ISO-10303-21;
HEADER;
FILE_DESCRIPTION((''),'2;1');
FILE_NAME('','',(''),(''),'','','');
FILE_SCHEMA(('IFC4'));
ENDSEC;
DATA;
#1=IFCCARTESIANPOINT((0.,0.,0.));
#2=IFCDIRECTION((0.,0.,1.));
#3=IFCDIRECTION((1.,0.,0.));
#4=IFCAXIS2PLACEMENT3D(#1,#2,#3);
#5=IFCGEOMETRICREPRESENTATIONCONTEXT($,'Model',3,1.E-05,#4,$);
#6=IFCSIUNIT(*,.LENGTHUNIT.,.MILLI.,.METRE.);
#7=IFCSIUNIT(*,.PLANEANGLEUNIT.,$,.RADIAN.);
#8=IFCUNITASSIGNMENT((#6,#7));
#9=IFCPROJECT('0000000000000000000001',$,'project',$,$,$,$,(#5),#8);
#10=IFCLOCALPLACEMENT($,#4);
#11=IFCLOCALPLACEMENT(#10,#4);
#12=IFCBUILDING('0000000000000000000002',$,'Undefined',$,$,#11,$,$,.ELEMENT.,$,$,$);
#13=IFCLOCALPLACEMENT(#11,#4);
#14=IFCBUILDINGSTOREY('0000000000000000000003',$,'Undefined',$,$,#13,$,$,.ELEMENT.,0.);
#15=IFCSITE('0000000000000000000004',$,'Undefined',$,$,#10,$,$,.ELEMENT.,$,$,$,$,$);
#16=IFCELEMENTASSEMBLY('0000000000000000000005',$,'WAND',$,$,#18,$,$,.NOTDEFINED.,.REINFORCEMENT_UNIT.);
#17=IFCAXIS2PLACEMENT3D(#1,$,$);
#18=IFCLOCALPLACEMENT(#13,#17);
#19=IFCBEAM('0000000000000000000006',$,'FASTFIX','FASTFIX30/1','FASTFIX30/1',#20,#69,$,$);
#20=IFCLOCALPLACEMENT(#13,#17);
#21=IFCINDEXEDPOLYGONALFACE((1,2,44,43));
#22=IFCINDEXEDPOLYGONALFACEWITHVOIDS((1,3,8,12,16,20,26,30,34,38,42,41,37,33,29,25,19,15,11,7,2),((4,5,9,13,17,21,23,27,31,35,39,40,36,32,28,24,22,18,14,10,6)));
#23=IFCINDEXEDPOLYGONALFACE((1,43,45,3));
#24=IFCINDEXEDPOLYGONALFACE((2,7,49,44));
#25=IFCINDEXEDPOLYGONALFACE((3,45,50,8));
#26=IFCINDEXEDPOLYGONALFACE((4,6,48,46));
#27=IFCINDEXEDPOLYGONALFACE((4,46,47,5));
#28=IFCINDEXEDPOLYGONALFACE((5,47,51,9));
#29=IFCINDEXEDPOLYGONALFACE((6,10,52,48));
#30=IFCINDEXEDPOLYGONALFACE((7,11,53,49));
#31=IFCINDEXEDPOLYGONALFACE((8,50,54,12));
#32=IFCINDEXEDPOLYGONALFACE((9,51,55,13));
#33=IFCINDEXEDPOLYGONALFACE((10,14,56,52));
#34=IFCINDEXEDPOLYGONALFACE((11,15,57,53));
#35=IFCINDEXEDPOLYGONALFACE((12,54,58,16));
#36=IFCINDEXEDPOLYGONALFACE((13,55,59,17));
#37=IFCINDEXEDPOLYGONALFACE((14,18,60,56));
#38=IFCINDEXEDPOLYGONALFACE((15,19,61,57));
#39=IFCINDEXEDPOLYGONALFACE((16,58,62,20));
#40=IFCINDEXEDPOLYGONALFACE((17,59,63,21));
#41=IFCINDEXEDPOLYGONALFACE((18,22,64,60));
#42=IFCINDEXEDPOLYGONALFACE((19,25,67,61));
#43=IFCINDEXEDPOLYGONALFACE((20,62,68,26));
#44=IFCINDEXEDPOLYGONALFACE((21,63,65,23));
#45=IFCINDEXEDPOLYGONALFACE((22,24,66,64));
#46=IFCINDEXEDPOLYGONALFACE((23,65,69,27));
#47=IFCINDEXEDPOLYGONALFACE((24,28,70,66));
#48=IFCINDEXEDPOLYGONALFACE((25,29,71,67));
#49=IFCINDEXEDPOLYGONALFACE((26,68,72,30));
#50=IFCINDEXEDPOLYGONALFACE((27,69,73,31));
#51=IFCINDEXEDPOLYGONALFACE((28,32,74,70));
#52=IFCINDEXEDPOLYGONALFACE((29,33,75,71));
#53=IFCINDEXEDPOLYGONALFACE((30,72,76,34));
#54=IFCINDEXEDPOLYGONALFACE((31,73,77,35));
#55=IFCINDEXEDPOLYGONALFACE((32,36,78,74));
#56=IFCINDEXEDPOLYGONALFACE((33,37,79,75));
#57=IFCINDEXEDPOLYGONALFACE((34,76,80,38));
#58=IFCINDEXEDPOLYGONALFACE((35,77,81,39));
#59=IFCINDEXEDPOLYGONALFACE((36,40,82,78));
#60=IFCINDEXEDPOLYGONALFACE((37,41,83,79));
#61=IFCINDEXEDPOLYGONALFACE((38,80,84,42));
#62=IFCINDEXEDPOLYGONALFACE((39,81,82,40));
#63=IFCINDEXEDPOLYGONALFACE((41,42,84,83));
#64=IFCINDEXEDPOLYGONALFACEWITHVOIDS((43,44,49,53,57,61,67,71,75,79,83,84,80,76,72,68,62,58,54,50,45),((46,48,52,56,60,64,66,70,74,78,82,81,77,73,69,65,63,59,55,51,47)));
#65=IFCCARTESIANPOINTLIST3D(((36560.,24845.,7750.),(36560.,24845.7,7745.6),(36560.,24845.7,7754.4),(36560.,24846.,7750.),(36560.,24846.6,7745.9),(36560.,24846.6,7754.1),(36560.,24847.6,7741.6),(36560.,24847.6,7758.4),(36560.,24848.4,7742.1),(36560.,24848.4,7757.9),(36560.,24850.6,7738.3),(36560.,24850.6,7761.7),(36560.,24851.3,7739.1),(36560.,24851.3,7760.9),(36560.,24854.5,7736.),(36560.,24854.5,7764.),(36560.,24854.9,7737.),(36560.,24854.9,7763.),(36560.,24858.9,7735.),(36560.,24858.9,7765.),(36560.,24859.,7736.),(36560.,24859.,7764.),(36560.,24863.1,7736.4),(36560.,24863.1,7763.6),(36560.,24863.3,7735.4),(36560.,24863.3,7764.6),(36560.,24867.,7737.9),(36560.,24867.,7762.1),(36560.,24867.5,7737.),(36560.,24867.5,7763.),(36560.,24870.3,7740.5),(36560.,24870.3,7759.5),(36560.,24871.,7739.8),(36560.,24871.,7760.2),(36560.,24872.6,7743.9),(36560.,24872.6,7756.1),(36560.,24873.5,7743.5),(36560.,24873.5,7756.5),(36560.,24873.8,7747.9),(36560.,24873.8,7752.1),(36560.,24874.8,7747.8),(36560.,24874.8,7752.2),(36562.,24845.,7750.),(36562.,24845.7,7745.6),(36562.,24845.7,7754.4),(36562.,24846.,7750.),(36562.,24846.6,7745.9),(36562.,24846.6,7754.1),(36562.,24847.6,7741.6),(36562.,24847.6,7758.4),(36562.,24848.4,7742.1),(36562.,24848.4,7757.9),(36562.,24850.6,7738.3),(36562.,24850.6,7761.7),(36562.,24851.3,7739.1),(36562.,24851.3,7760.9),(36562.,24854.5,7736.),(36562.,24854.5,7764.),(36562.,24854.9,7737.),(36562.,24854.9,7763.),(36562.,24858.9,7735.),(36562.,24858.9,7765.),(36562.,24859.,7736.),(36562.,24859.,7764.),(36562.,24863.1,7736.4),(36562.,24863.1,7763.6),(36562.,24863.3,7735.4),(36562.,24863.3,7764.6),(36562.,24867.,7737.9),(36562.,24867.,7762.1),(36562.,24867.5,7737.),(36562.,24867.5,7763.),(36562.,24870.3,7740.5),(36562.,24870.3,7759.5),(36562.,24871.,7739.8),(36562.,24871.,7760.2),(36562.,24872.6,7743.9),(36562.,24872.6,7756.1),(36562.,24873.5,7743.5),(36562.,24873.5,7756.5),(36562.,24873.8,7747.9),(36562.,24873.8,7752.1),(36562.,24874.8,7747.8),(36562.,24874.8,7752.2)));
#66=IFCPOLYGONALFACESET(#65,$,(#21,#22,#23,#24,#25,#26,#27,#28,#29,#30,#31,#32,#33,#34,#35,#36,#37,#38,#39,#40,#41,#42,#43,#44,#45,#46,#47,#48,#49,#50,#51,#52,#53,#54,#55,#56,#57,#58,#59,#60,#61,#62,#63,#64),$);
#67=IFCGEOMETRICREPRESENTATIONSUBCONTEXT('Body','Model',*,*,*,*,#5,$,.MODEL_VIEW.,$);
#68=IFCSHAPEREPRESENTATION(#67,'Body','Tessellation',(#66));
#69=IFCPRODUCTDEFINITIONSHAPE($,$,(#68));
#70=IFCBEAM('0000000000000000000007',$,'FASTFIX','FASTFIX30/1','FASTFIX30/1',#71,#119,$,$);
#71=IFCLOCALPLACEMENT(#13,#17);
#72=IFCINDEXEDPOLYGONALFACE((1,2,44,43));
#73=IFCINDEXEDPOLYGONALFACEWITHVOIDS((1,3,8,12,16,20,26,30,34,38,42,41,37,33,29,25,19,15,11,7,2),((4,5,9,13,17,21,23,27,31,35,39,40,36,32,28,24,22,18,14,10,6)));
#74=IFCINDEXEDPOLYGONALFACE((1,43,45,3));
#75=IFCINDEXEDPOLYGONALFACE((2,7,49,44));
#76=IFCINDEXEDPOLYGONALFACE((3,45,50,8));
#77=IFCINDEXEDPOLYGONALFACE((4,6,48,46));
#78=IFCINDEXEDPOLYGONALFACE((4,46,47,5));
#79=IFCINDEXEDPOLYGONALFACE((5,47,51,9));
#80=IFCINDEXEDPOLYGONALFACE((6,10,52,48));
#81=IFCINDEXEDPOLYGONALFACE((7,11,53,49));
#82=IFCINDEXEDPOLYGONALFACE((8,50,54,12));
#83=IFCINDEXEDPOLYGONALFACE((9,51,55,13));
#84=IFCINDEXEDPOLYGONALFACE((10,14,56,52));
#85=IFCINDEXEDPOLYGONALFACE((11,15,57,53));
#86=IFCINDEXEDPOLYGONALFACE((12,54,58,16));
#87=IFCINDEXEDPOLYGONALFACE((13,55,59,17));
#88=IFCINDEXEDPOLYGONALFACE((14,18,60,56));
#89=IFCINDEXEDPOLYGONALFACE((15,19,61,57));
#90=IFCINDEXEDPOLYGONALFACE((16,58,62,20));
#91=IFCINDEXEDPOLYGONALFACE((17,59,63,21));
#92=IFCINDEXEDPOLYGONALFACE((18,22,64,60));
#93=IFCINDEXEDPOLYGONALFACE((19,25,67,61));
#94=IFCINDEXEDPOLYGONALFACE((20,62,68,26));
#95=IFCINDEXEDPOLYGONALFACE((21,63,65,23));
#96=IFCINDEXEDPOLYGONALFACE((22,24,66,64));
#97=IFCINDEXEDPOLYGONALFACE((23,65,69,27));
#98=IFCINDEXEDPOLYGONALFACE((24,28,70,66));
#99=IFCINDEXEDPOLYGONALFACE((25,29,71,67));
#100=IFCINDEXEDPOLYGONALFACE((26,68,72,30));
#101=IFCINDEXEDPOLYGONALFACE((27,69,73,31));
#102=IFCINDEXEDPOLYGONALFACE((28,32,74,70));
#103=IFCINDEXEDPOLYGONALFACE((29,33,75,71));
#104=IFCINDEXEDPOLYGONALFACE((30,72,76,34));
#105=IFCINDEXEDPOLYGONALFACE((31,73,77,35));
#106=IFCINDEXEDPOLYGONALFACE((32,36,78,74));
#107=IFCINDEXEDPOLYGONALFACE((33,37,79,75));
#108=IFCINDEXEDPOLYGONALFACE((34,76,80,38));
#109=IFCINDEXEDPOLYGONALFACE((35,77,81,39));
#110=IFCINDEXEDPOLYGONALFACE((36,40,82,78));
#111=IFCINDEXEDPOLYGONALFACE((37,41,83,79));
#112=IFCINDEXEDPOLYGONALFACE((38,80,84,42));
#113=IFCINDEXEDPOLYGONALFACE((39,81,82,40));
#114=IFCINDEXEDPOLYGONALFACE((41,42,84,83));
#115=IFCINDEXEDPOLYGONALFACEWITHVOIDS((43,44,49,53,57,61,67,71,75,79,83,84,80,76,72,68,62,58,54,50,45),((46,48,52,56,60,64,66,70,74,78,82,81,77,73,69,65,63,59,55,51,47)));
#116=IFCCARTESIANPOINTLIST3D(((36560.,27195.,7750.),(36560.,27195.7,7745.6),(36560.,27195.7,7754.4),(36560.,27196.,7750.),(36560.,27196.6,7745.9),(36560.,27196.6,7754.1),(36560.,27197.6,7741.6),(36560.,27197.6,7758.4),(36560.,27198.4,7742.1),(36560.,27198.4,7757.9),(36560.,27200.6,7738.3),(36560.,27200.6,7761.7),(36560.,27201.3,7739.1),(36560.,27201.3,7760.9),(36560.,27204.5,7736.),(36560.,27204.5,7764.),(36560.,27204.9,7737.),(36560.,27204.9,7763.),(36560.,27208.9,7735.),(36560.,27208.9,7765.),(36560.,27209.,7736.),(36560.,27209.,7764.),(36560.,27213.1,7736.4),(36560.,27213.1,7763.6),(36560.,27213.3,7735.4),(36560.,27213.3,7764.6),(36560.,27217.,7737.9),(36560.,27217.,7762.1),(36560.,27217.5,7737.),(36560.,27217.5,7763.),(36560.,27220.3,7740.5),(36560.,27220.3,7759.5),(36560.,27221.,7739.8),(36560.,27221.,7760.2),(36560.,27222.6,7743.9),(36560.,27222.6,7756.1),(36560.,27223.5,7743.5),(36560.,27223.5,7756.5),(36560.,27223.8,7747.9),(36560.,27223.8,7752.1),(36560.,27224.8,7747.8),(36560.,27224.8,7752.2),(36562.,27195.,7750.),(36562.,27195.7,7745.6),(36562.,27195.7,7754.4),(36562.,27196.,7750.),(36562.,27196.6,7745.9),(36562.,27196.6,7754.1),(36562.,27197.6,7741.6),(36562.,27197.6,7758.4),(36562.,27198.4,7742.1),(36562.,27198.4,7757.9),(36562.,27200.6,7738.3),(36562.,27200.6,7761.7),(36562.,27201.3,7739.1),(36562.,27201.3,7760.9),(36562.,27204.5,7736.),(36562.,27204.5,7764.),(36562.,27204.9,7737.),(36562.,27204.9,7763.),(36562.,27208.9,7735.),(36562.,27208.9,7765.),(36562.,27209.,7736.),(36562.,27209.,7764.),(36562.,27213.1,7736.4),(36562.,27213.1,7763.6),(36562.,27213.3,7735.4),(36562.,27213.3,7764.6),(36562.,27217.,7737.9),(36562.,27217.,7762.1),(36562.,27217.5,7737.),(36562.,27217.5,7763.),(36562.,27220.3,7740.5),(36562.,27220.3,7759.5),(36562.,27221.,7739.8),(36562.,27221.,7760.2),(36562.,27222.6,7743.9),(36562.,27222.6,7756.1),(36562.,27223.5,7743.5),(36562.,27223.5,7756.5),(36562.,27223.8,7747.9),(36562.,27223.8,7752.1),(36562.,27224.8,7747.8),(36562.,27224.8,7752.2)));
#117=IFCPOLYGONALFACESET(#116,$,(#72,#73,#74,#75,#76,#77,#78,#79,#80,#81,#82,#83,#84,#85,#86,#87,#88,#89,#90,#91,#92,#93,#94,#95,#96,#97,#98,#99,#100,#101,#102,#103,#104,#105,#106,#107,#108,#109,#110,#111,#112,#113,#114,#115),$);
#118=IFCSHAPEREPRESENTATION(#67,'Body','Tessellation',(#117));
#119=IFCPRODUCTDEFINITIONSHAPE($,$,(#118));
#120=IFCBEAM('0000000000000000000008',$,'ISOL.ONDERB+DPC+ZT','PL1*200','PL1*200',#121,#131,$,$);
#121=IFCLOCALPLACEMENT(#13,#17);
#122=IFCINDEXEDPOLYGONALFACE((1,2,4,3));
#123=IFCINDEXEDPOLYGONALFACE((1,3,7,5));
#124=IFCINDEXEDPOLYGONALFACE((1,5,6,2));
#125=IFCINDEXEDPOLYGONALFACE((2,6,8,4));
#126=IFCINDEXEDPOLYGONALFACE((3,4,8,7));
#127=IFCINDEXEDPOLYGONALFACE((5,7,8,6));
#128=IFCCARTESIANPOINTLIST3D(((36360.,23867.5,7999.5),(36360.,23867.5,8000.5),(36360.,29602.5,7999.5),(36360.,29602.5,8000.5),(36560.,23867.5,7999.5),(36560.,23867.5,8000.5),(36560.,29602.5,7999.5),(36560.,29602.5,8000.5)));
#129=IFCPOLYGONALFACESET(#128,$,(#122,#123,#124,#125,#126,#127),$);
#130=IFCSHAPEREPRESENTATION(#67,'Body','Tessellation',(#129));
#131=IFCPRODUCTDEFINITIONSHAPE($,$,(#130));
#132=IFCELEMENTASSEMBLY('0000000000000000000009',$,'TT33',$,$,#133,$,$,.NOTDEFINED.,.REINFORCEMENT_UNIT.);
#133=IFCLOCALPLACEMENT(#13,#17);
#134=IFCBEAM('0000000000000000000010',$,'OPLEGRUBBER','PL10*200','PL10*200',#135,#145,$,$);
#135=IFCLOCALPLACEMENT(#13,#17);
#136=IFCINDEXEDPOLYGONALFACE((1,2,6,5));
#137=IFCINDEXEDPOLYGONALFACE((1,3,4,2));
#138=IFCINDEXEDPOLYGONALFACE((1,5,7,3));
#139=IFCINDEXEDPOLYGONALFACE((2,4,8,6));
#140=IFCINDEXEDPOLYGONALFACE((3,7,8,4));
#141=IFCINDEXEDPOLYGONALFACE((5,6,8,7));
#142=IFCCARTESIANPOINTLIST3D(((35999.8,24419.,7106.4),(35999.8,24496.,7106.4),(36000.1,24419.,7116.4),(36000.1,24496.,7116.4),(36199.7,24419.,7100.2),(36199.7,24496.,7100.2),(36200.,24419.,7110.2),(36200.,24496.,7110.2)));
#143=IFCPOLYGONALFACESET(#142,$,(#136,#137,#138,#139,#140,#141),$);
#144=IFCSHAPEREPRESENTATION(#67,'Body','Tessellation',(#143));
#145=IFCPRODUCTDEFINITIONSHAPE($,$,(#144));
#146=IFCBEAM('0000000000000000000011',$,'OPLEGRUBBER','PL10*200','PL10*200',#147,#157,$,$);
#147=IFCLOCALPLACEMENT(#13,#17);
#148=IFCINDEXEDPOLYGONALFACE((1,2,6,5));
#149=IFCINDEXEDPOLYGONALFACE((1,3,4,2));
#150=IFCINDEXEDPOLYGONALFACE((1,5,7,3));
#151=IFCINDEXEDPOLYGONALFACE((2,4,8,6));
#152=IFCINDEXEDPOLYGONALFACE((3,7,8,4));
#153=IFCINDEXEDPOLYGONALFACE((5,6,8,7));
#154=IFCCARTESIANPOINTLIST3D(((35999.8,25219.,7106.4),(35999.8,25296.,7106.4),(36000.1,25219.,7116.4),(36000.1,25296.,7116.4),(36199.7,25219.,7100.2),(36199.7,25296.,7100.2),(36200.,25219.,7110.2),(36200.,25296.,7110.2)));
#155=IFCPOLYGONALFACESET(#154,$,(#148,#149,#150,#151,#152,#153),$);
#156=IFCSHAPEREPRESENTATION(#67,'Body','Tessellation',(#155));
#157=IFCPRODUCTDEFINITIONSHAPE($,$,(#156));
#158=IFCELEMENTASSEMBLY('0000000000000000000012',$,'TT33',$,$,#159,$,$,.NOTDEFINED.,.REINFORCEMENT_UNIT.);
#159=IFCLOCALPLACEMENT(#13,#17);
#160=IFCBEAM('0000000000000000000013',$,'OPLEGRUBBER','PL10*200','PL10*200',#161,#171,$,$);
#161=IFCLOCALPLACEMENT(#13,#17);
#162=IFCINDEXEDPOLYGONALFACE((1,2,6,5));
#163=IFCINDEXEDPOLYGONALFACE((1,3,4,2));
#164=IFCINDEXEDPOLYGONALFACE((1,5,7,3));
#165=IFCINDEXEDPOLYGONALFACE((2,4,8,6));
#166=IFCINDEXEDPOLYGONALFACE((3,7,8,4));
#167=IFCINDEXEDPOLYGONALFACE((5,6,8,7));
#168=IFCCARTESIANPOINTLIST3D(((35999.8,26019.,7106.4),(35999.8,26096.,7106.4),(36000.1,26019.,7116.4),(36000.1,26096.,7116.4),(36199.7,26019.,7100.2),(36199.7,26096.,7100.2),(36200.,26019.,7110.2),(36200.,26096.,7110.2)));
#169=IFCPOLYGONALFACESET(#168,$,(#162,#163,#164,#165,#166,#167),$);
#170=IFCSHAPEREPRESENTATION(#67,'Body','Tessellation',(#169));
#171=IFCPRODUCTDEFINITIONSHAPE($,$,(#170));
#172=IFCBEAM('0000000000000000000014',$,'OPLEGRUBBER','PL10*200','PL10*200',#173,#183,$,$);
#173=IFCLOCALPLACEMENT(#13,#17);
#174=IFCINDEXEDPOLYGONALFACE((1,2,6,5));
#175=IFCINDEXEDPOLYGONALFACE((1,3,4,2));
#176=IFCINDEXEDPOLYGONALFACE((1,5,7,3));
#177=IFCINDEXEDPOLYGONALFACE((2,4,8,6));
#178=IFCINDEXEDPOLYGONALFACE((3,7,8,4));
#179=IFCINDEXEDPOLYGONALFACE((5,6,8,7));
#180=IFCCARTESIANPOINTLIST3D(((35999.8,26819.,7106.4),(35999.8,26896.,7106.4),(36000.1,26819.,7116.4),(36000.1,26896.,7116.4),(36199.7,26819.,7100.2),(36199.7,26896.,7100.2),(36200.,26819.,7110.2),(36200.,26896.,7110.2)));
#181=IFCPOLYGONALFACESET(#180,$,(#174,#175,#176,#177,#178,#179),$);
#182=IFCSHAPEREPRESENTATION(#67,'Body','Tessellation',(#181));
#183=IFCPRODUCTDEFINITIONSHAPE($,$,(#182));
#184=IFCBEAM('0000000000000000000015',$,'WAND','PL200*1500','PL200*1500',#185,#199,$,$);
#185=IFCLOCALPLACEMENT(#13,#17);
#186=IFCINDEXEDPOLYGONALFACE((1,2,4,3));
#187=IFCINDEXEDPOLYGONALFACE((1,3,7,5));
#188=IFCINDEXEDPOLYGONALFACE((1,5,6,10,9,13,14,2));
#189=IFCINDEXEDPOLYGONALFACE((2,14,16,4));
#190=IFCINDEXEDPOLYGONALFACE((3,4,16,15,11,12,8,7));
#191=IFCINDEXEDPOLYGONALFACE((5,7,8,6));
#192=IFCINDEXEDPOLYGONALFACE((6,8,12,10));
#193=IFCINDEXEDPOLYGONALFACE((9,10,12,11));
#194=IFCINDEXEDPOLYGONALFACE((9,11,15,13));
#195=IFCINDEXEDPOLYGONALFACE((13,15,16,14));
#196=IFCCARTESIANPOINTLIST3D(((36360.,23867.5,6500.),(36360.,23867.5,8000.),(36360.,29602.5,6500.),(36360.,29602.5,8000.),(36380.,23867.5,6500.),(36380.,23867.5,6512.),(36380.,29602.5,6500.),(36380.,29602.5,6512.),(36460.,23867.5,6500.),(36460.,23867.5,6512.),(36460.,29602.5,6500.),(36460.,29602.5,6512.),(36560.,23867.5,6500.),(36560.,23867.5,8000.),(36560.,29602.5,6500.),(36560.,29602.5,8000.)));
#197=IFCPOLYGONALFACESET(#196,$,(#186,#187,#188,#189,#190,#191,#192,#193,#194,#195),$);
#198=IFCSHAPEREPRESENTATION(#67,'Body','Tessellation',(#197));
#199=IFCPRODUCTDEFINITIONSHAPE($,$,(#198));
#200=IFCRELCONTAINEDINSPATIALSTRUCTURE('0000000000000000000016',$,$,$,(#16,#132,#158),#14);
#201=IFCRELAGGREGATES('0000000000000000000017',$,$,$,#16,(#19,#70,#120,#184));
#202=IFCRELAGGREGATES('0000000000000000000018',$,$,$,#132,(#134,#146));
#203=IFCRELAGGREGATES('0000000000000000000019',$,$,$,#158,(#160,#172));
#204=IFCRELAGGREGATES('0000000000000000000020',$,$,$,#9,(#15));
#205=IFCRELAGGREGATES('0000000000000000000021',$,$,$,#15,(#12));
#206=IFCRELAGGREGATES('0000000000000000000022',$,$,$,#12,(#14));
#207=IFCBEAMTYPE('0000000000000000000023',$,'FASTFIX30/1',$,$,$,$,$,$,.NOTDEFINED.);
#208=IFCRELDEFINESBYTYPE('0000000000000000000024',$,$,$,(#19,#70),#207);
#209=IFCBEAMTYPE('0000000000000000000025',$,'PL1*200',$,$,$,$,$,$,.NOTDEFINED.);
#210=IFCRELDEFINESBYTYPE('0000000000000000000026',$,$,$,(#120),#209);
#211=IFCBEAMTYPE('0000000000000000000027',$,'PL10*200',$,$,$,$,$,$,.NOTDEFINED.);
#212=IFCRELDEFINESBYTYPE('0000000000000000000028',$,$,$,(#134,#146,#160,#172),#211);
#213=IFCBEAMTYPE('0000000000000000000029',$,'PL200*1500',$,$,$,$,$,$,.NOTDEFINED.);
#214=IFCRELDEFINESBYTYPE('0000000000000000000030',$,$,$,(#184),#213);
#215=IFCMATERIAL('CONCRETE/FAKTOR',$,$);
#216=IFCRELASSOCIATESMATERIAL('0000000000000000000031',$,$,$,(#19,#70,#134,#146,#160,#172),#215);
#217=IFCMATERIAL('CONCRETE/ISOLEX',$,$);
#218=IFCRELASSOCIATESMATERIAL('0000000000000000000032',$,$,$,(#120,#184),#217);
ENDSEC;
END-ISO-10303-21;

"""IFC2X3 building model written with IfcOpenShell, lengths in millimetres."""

from ifc_helpers import new_model, si_unit, frame, frame_2d, origin_with_axes, place, context, subcontext, project, spatial, rectangle, hollow_circle, extrude, boolean, material, type_object, element, aggregate, save


model = new_model("IFC2X3")

# Units and contexts
model_context = context("Model", 3, precision=1e-05, world=origin_with_axes())
body_context = subcontext(model_context, "Body", "Model", "MODEL_VIEW")
ifc_project = project(units=[si_unit("LENGTHUNIT", "METRE", prefix="MILLI"), si_unit("PLANEANGLEUNIT", "RADIAN")], contexts=[model_context])

# Site, building, storey
site_placement = place(None, origin_with_axes())
site = spatial("IfcSite", under=ifc_project, at=site_placement, Name="Undefined", CompositionType="ELEMENT")
building_placement = place(site_placement, origin_with_axes())
building = spatial("IfcBuilding", under=site, at=building_placement, Name="Undefined", CompositionType="ELEMENT")
storey_placement = place(building_placement, origin_with_axes())
storey = spatial("IfcBuildingStorey", under=building, at=storey_placement, Name="Undefined", CompositionType="ELEMENT", Elevation=0.0)

# Shared definitions
ifc_material_1 = material(Name="CONCRETE/FAKTOR")

# Element assembly
assembly_1_placement = place(storey_placement, origin_with_axes())
assembly_1 = element("IfcElementAssembly", 1, at=assembly_1_placement, inside=storey, Name="WAND", AssemblyPlace="NOTDEFINED", PredefinedType="REINFORCEMENT_UNIT")

# Beams
beam_type_1 = type_object("IfcBeamType", Name="FASTFIX30/1", PredefinedType="NOTDEFINED")
beam_1_placement = place(assembly_1_placement, frame((36560.0, 24860.0, 7750.0), z_axis=(0.0, 0.0, 1.0), x_axis=(1.0, 0.0, 0.0)))
beam_1 = element("IfcBeam", 2, at=beam_1_placement, type_object=beam_type_1, material=ifc_material_1, Name="FASTFIX", Description="FASTFIX30/1", ObjectType="FASTFIX30/1", context=body_context, shape_type="SweptSolid", body=[
    extrude(hollow_circle(Radius=15.0, WallThickness=1.0, at=frame_2d((0.0, 0.0), x_axis=(1.0, 0.0))), frame((2.0, 0.0, 0.0), z_axis=(-1.0, 0.0, 0.0), x_axis=(0.0, -1.0, 0.0)), (0.0, 0.0, 1.0), 2.0),
])
beam_2_placement = place(assembly_1_placement, frame((36560.0, 27210.0, 7750.0), z_axis=(0.0, 0.0, 1.0), x_axis=(1.0, 0.0, 0.0)))
beam_2 = element("IfcBeam", 3, at=beam_2_placement, type_object=beam_type_1, material=ifc_material_1, Name="FASTFIX", Description="FASTFIX30/1", ObjectType="FASTFIX30/1", context=body_context, shape_type="SweptSolid", body=[
    extrude(hollow_circle(Radius=15.0, WallThickness=1.0, at=frame_2d((0.0, 0.0), x_axis=(1.0, 0.0))), frame((2.0, 0.0, 0.0), z_axis=(-1.0, 0.0, 0.0), x_axis=(0.0, -1.0, 0.0)), (0.0, 0.0, 1.0), 2.0),
])
ifc_material_2 = material(Name="CONCRETE/ISOLEX")
beam_type_2 = type_object("IfcBeamType", Name="PL1*200", PredefinedType="NOTDEFINED")
beam_3_placement = place(assembly_1_placement, frame((36460.0, 23867.5, 8000.0), z_axis=(1.0, 0.0, 0.0), x_axis=(0.0, 1.0, 0.0)))
beam_3 = element("IfcBeam", 4, at=beam_3_placement, type_object=beam_type_2, material=ifc_material_2, Name="ISOL.ONDERB+DPC+ZT", Description="PL1*200", ObjectType="PL1*200", context=body_context, shape_type="SweptSolid", body=[
    extrude(rectangle(XDim=1.0, YDim=200.0, at=frame_2d((0.0, 0.0), x_axis=(1.0, 0.0))), frame((5735.0, 0.0, 0.0), z_axis=(-1.0, 0.0, 0.0), x_axis=(0.0, -1.0, 0.0)), (0.0, 0.0, 1.0), 5735.0),
])

# Element assemblies, beams
assembly_2_placement = place(storey_placement, origin_with_axes())
assembly_2 = element("IfcElementAssembly", 5, at=assembly_2_placement, inside=storey, Name="TT33", AssemblyPlace="NOTDEFINED", PredefinedType="REINFORCEMENT_UNIT")
beam_type_3 = type_object("IfcBeamType", Name="PL10*200", PredefinedType="NOTDEFINED")
beam_4_placement = place(assembly_2_placement, frame((36099.9, 24496.0, 7108.3), z_axis=(-0.999516, 0.0, 0.031107), x_axis=(0.0, -1.0, 0.0)))
beam_4 = element("IfcBeam", 6, at=beam_4_placement, type_object=beam_type_3, material=ifc_material_1, Name="OPLEGRUBBER", Description="PL10*200", ObjectType="PL10*200", context=body_context, shape_type="SweptSolid", body=[
    extrude(rectangle(XDim=10.0, YDim=200.0, at=frame_2d((0.0, 0.0), x_axis=(1.0, 0.0))), frame((77.0, 0.0, 0.0), z_axis=(-1.0, 0.0, 0.0), x_axis=(0.0, -1.0, 0.0)), (0.0, 0.0, 1.0), 77.0),
])
beam_5_placement = place(assembly_2_placement, frame((36099.9, 25296.0, 7108.3), z_axis=(-0.999516, 0.0, 0.031107), x_axis=(0.0, -1.0, 0.0)))
beam_5 = element("IfcBeam", 7, at=beam_5_placement, type_object=beam_type_3, material=ifc_material_1, Name="OPLEGRUBBER", Description="PL10*200", ObjectType="PL10*200", context=body_context, shape_type="SweptSolid", body=[
    extrude(rectangle(XDim=10.0, YDim=200.0, at=frame_2d((0.0, 0.0), x_axis=(1.0, 0.0))), frame((77.0, 0.0, 0.0), z_axis=(-1.0, 0.0, 0.0), x_axis=(0.0, -1.0, 0.0)), (0.0, 0.0, 1.0), 77.0),
])
assembly_3_placement = place(storey_placement, origin_with_axes())
assembly_3 = element("IfcElementAssembly", 8, at=assembly_3_placement, inside=storey, Name="TT33", AssemblyPlace="NOTDEFINED", PredefinedType="REINFORCEMENT_UNIT")
beam_6_placement = place(assembly_3_placement, frame((36099.9, 26096.0, 7108.3), z_axis=(-0.999516, 0.0, 0.031107), x_axis=(0.0, -1.0, 0.0)))
beam_6 = element("IfcBeam", 9, at=beam_6_placement, type_object=beam_type_3, material=ifc_material_1, Name="OPLEGRUBBER", Description="PL10*200", ObjectType="PL10*200", context=body_context, shape_type="SweptSolid", body=[
    extrude(rectangle(XDim=10.0, YDim=200.0, at=frame_2d((0.0, 0.0), x_axis=(1.0, 0.0))), frame((77.0, 0.0, 0.0), z_axis=(-1.0, 0.0, 0.0), x_axis=(0.0, -1.0, 0.0)), (0.0, 0.0, 1.0), 77.0),
])
beam_7_placement = place(assembly_3_placement, frame((36099.9, 26896.0, 7108.3), z_axis=(-0.999516, 0.0, 0.031107), x_axis=(0.0, -1.0, 0.0)))
beam_7 = element("IfcBeam", 10, at=beam_7_placement, type_object=beam_type_3, material=ifc_material_1, Name="OPLEGRUBBER", Description="PL10*200", ObjectType="PL10*200", context=body_context, shape_type="SweptSolid", body=[
    extrude(rectangle(XDim=10.0, YDim=200.0, at=frame_2d((0.0, 0.0), x_axis=(1.0, 0.0))), frame((77.0, 0.0, 0.0), z_axis=(-1.0, 0.0, 0.0), x_axis=(0.0, -1.0, 0.0)), (0.0, 0.0, 1.0), 77.0),
])

# Beam
beam_type_4 = type_object("IfcBeamType", Name="PL200*1500", PredefinedType="NOTDEFINED")
beam_8_placement = place(assembly_1_placement, frame((36460.0, 23867.5, 7250.0), z_axis=(0.0, 0.0, 1.0), x_axis=(0.0, 1.0, 0.0)))
beam_8 = element("IfcBeam", 11, at=beam_8_placement, type_object=beam_type_4, material=ifc_material_2, Name="WAND", Description="PL200*1500", ObjectType="PL200*1500", context=body_context, shape_type="CSG", body=[
    boolean("DIFFERENCE", extrude(rectangle(XDim=200.0, YDim=1500.0, at=frame_2d((0.0, 0.0), x_axis=(1.0, 0.0))), frame((5735.0, 0.0, 0.0), z_axis=(-1.0, 0.0, 0.0), x_axis=(0.0, -1.0, 0.0)), (0.0, 0.0, 1.0), 5735.0), extrude(rectangle(XDim=12.0, YDim=80.0, at=frame_2d((0.0, 0.0), x_axis=(1.0, 0.0))), frame((5735.0, 40.0, -744.0), z_axis=(-1.0, 0.0, 0.0), x_axis=(0.0, 0.0, -1.0)), (0.0, 0.0, 1.0), 5735.0)),
])
aggregate(assembly_1, [beam_1, beam_2, beam_3, beam_8])

aggregate(assembly_2, [beam_4, beam_5])
aggregate(assembly_3, [beam_6, beam_7])

save(model, "model.ifc")
